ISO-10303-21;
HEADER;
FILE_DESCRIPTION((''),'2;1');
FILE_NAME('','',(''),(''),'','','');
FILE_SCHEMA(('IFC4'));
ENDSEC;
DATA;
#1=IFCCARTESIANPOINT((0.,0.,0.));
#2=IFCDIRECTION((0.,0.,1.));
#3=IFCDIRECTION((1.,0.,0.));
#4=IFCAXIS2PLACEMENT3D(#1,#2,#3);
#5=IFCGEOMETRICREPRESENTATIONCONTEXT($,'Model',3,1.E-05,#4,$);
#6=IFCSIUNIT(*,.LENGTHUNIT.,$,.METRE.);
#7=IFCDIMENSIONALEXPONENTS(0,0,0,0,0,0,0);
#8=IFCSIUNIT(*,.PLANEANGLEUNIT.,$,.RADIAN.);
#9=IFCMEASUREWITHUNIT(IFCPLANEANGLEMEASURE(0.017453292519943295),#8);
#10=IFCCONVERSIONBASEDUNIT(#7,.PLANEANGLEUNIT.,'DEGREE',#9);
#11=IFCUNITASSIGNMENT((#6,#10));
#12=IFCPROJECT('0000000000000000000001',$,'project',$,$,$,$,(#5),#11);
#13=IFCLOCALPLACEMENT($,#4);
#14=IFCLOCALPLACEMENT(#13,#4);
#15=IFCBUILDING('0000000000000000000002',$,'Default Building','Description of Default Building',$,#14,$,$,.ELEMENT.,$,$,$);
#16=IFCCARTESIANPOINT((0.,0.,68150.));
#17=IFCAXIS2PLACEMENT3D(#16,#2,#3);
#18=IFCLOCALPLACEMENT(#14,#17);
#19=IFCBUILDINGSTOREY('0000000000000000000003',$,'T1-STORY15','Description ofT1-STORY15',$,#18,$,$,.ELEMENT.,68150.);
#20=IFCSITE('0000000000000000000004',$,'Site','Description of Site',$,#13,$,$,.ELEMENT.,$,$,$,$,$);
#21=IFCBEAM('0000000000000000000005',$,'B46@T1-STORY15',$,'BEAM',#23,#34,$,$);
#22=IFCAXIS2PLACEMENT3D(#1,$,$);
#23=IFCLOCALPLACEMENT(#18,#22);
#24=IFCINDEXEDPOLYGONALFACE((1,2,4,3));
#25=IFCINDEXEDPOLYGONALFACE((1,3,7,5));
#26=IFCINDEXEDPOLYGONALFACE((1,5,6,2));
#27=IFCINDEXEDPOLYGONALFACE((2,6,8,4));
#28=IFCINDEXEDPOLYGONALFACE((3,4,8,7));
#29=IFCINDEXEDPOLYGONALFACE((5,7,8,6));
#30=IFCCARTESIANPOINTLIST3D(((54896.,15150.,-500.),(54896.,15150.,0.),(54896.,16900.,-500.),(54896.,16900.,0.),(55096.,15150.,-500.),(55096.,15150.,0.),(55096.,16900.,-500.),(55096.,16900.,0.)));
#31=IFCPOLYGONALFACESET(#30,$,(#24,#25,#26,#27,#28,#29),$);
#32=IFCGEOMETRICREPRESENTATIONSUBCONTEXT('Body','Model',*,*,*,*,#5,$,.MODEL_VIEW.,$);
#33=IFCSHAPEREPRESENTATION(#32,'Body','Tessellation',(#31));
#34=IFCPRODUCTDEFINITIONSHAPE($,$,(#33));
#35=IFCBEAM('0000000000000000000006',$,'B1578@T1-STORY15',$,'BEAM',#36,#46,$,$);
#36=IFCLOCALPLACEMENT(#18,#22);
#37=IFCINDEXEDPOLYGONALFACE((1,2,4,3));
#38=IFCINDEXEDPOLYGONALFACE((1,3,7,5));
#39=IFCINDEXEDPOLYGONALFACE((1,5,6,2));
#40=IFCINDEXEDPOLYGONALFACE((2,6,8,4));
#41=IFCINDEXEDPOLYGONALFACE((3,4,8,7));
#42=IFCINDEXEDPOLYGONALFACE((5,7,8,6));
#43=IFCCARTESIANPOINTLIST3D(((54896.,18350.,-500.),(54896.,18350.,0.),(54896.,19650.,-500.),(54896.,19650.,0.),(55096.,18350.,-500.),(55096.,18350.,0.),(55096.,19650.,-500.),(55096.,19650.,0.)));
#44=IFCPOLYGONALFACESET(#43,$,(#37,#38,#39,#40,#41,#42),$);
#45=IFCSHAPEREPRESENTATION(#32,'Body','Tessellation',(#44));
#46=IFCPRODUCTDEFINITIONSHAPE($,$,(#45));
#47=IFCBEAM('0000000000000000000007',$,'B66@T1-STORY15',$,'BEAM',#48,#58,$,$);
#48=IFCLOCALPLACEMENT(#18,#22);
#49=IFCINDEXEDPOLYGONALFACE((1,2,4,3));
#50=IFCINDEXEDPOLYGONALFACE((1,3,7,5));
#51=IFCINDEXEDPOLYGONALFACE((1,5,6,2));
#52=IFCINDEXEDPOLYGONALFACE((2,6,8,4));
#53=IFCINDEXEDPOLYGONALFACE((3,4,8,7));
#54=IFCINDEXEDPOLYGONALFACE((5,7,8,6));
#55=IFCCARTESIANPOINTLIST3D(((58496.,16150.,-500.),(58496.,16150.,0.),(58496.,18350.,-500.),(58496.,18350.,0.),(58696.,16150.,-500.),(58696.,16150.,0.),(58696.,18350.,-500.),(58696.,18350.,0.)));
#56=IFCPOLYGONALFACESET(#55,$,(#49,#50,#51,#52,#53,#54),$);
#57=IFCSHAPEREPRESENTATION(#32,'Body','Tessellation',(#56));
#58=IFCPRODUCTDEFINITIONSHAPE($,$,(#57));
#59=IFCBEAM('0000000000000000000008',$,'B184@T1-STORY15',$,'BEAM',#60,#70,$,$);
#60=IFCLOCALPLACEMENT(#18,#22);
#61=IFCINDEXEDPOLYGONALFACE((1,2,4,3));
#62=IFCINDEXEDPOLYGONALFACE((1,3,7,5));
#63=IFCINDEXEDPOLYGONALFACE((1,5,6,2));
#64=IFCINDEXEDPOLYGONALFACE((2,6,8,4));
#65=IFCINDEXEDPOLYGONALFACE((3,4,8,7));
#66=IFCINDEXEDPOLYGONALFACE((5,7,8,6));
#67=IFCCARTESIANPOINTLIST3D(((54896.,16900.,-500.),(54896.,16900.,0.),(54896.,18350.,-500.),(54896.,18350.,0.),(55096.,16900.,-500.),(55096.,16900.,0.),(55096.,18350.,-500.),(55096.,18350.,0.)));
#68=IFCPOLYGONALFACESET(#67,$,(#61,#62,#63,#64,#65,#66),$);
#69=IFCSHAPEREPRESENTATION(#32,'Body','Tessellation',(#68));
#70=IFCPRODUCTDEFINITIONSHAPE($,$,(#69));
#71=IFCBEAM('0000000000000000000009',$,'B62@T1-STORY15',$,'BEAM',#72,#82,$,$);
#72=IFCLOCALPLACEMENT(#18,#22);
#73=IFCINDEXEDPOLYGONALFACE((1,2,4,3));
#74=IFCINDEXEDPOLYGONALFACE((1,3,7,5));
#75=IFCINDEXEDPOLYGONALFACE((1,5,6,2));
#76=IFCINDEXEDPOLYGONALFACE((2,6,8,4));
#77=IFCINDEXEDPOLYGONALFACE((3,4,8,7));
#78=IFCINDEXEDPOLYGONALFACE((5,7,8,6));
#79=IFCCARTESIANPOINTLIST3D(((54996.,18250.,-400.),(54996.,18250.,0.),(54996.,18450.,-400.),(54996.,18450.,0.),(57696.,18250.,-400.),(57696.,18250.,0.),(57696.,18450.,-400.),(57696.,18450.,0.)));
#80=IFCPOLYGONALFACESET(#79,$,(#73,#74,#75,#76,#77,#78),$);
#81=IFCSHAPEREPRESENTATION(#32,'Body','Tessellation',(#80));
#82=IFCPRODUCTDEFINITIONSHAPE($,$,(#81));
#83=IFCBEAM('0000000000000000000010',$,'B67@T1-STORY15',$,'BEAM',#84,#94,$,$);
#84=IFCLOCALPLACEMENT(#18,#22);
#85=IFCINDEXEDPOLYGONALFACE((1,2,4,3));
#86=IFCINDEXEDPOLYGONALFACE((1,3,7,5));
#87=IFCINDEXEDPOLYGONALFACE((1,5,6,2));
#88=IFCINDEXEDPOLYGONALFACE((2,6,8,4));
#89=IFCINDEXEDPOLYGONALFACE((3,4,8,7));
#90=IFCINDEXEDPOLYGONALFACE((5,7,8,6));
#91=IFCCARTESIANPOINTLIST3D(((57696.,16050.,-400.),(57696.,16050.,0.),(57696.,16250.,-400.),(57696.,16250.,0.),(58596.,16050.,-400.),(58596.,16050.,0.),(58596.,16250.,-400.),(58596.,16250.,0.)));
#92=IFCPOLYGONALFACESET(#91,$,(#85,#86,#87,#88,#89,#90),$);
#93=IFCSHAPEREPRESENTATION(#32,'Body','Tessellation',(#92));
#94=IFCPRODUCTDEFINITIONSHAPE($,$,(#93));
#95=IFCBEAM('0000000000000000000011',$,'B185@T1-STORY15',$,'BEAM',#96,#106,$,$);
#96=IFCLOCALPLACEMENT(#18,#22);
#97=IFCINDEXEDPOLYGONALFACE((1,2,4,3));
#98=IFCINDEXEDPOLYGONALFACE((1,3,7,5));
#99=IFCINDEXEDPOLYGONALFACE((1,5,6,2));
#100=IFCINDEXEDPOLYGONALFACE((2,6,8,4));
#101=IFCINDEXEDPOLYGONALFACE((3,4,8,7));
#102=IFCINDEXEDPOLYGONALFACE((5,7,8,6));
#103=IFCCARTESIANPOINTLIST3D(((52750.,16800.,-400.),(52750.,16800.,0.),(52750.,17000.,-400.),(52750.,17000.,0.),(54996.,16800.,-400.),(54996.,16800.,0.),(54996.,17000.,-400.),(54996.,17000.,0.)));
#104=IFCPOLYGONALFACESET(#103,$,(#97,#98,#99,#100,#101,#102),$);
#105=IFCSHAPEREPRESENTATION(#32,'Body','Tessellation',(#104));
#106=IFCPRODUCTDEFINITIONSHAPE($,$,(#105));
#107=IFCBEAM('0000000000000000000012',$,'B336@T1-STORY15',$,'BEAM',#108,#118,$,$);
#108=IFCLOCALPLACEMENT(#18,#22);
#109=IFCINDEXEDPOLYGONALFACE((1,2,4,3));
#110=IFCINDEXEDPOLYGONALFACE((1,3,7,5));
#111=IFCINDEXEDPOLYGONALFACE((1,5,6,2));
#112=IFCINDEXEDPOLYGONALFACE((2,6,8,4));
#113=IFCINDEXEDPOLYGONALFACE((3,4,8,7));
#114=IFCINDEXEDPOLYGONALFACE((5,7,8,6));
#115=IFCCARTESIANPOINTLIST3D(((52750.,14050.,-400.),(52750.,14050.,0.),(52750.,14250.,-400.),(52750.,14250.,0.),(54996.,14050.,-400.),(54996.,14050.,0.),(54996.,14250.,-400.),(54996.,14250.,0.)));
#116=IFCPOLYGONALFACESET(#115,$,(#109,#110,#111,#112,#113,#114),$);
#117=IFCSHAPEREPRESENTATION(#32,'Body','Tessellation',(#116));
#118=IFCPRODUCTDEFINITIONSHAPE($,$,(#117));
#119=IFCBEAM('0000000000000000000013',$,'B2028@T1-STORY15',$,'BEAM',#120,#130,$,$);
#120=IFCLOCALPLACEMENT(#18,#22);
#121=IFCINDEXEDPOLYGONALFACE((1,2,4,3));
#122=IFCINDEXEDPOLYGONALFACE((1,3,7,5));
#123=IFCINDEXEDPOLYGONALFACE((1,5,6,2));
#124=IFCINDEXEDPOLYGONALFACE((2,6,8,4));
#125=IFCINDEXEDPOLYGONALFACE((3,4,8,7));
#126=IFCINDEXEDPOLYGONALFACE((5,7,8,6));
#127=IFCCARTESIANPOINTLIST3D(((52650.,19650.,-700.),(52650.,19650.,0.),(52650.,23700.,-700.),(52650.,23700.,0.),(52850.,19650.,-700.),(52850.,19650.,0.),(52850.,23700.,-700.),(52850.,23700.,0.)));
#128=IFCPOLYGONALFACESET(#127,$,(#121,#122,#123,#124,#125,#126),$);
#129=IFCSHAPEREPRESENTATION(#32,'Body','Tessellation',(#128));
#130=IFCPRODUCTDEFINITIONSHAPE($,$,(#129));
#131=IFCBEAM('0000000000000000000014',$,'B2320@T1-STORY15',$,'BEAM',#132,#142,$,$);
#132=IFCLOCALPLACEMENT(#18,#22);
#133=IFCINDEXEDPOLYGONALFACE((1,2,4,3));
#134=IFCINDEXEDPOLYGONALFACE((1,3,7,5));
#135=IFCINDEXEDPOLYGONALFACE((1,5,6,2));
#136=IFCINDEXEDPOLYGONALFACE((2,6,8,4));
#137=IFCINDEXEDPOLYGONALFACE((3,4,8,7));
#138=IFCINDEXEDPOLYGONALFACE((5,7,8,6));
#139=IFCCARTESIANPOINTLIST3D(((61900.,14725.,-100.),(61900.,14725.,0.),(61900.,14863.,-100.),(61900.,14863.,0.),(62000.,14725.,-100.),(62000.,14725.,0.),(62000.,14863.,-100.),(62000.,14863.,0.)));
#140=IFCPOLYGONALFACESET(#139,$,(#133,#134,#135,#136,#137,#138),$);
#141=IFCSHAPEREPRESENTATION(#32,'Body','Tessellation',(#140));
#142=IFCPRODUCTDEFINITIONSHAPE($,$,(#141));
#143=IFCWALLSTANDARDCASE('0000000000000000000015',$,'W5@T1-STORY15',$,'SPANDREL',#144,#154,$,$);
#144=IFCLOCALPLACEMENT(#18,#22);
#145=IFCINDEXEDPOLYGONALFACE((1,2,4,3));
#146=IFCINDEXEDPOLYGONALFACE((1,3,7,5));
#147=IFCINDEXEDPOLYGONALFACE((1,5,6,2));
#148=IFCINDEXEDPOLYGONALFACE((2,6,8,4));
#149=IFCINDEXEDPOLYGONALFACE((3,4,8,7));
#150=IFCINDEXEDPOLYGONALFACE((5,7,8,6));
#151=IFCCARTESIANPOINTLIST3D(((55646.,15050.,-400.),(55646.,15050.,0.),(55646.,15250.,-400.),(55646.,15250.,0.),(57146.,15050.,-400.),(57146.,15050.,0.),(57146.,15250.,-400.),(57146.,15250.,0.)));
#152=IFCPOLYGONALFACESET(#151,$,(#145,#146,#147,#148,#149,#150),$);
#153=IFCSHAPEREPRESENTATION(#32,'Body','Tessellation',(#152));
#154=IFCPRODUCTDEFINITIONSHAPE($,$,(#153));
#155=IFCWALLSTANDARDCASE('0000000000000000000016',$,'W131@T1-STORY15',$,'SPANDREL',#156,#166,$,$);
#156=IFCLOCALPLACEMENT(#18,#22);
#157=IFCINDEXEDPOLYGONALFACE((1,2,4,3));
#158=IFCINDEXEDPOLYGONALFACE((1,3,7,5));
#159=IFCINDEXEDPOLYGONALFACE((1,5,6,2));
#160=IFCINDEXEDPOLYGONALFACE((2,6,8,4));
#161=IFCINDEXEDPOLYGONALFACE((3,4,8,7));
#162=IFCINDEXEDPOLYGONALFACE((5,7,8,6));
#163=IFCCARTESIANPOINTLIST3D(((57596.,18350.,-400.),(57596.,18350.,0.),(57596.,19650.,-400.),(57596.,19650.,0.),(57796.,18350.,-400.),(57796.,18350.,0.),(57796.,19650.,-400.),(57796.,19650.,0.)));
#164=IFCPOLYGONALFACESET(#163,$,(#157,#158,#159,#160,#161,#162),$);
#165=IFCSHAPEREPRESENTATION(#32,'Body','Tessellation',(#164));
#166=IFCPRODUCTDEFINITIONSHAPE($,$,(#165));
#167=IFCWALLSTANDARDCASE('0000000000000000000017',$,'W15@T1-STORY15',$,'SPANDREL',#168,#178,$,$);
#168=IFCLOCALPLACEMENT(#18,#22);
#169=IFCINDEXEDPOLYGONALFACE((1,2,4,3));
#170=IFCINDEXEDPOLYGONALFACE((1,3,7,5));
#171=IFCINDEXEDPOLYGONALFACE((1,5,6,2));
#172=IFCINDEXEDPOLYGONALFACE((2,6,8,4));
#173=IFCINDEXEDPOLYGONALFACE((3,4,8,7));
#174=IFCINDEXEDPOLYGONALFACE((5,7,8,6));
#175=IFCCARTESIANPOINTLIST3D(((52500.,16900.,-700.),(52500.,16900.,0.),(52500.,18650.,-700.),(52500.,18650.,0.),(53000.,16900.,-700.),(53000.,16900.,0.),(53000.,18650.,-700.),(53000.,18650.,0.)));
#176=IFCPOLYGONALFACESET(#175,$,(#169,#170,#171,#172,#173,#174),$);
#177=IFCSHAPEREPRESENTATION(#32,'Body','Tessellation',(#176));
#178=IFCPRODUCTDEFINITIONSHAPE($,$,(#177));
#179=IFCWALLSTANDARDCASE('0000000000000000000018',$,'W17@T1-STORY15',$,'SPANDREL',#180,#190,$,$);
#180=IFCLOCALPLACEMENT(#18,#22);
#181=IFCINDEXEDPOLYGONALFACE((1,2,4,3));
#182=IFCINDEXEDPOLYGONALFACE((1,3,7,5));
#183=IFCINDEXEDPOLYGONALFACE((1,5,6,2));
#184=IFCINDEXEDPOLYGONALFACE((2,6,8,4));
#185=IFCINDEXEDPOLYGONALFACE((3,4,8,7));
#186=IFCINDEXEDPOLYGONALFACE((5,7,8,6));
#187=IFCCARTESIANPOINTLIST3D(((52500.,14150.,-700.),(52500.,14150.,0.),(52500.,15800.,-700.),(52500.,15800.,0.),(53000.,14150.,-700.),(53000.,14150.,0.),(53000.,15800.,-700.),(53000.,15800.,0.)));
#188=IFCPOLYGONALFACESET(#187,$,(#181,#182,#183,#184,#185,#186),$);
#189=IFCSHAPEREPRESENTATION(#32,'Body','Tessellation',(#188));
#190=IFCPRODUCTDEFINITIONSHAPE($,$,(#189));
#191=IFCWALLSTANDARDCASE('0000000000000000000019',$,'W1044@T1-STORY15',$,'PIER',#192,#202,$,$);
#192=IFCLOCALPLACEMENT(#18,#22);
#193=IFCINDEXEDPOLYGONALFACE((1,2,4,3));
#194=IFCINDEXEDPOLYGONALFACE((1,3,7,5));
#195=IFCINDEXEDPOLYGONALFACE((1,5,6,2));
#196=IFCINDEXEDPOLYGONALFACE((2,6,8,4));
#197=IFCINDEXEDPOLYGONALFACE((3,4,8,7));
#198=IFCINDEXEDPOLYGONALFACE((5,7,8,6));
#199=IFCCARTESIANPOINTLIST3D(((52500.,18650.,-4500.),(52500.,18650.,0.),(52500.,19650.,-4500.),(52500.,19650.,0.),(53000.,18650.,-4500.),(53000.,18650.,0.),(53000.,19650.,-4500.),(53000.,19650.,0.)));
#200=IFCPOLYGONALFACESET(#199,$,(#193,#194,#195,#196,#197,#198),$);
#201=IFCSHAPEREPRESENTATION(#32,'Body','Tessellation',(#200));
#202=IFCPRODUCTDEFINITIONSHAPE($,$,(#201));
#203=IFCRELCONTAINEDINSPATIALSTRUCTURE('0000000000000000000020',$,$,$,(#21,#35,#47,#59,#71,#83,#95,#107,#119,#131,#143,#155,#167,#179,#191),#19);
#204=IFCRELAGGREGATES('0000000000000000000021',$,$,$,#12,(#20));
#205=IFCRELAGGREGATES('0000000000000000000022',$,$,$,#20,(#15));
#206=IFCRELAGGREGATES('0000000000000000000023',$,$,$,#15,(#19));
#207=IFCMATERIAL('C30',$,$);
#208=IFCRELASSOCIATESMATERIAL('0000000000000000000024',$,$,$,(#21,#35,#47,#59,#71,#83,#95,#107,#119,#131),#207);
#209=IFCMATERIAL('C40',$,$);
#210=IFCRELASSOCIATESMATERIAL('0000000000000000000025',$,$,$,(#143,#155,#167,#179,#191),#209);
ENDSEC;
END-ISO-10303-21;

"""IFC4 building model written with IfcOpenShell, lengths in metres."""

from ifc_helpers import new_model, entity, si_unit, converted_unit, frame, origin_with_axes, place, context, subcontext, project, spatial, indexed_curve, rectangle, outline, extrude, material, element, save


model = new_model("IFC4")

# Units and contexts
model_context = context("Model", 3, precision=1e-05, world=origin_with_axes())
body_context = subcontext(model_context, "Body", "Model", "MODEL_VIEW")
ifc_project = project(units=[si_unit("LENGTHUNIT", "METRE"), converted_unit("PLANEANGLEUNIT", "DEGREE", entity("IfcPlaneAngleMeasure", 0.017453292519943295), si_unit("PLANEANGLEUNIT", "RADIAN"), dimensions=[0, 0, 0, 0, 0, 0, 0])], contexts=[model_context])

# Site, building, storey
site_placement = place(None, origin_with_axes())
site = spatial("IfcSite", under=ifc_project, at=site_placement, Name="Site", Description="Description of Site", CompositionType="ELEMENT")
building_placement = place(site_placement, origin_with_axes())
building = spatial("IfcBuilding", under=site, at=building_placement, Name="Default Building", Description="Description of Default Building", CompositionType="ELEMENT")
storey_placement = place(building_placement, frame((0.0, 0.0, 68150.0), z_axis=(0.0, 0.0, 1.0), x_axis=(1.0, 0.0, 0.0)))
storey = spatial("IfcBuildingStorey", under=building, at=storey_placement, Name="T1-STORY15", Description="Description ofT1-STORY15", CompositionType="ELEMENT", Elevation=68150.0)

# Beams
ifc_material_1 = material(Name="C30")
beam_1_placement = place(storey_placement, frame((54996.0, 15150.0, -250.0), z_axis=(0.0, 1.0, 0.0), x_axis=(-1.0, 0.0, 0.0)))
element("IfcBeam", 1, at=beam_1_placement, inside=storey, material=ifc_material_1, Name="B46@T1-STORY15", ObjectType="BEAM", context=body_context, shape_type="SweptSolid", body=[
    extrude(rectangle(XDim=200.0, YDim=500.0), origin_with_axes(), (0.0, 0.0, 1.0), 1750.0),
])
beam_2_placement = place(storey_placement, frame((54996.0, 18350.0, -250.0), z_axis=(0.0, 1.0, 0.0), x_axis=(-1.0, 0.0, 0.0)))
element("IfcBeam", 2, at=beam_2_placement, inside=storey, material=ifc_material_1, Name="B1578@T1-STORY15", ObjectType="BEAM", context=body_context, shape_type="SweptSolid", body=[
    extrude(rectangle(XDim=200.0, YDim=500.0), origin_with_axes(), (0.0, 0.0, 1.0), 1300.0),
])
beam_3_placement = place(storey_placement, frame((58596.0, 16150.0, -250.0), z_axis=(0.0, 1.0, 0.0), x_axis=(-1.0, 0.0, 0.0)))
element("IfcBeam", 3, at=beam_3_placement, inside=storey, material=ifc_material_1, Name="B66@T1-STORY15", ObjectType="BEAM", context=body_context, shape_type="SweptSolid", body=[
    extrude(rectangle(XDim=200.0, YDim=500.0), origin_with_axes(), (0.0, 0.0, 1.0), 2200.0),
])
beam_4_placement = place(storey_placement, frame((54996.0, 16900.0, -250.0), z_axis=(0.0, 1.0, 0.0), x_axis=(-1.0, 0.0, 0.0)))
element("IfcBeam", 4, at=beam_4_placement, inside=storey, material=ifc_material_1, Name="B184@T1-STORY15", ObjectType="BEAM", context=body_context, shape_type="SweptSolid", body=[
    extrude(rectangle(XDim=200.0, YDim=500.0), origin_with_axes(), (0.0, 0.0, 1.0), 1450.0),
])
beam_5_placement = place(storey_placement, frame((54996.0, 18350.0, -200.0), z_axis=(1.0, 0.0, 0.0), x_axis=(0.0, 1.0, 0.0)))
element("IfcBeam", 5, at=beam_5_placement, inside=storey, material=ifc_material_1, Name="B62@T1-STORY15", ObjectType="BEAM", context=body_context, shape_type="SweptSolid", body=[
    extrude(rectangle(XDim=200.0, YDim=400.0), origin_with_axes(), (0.0, 0.0, 1.0), 2700.0),
])
beam_6_placement = place(storey_placement, frame((57696.0, 16150.0, -200.0), z_axis=(1.0, 0.0, 0.0), x_axis=(0.0, 1.0, 0.0)))
element("IfcBeam", 6, at=beam_6_placement, inside=storey, material=ifc_material_1, Name="B67@T1-STORY15", ObjectType="BEAM", context=body_context, shape_type="SweptSolid", body=[
    extrude(rectangle(XDim=200.0, YDim=400.0), origin_with_axes(), (0.0, 0.0, 1.0), 900.0),
])
for number, where, z_axis, x_axis, name in (
    (7, (52750.0, 16900.0, -200.0), (1.0, 0.0, 0.0), (0.0, 1.0, 0.0), "B185@T1-STORY15"),
    (8, (52750.0, 14150.0, -200.0), (1.0, 0.0, 0.0), (0.0, 1.0, 0.0), "B336@T1-STORY15"),
):
    element("IfcBeam", number, at=place(storey_placement, frame(where, z_axis=z_axis, x_axis=x_axis)), inside=storey, material=ifc_material_1, Name=name, ObjectType="BEAM", context=body_context, shape_type="SweptSolid", body=[
        extrude(rectangle(XDim=200.0, YDim=400.0), origin_with_axes(), (0.0, 0.0, 1.0), 2246.0),
    ])
beam_7_placement = place(storey_placement, frame((52750.0, 19650.0, -350.0), z_axis=(0.0, 1.0, 0.0), x_axis=(-1.0, 0.0, 0.0)))
element("IfcBeam", 9, at=beam_7_placement, inside=storey, material=ifc_material_1, Name="B2028@T1-STORY15", ObjectType="BEAM", context=body_context, shape_type="SweptSolid", body=[
    extrude(rectangle(XDim=200.0, YDim=700.0), origin_with_axes(), (0.0, 0.0, 1.0), 4050.0),
])
beam_8_placement = place(storey_placement, frame((61950.0, 14725.0, -50.0), z_axis=(0.0, 1.0, 0.0), x_axis=(-1.0, 0.0, 0.0)))
element("IfcBeam", 10, at=beam_8_placement, inside=storey, material=ifc_material_1, Name="B2320@T1-STORY15", ObjectType="BEAM", context=body_context, shape_type="SweptSolid", body=[
    extrude(rectangle(XDim=100.0, YDim=100.0), origin_with_axes(), (0.0, 0.0, 1.0), 138.0),
])

# Walls
ifc_material_2 = material(Name="C40")
wall_1_placement = place(storey_placement, frame((55646.0, 15150.0, -400.0), z_axis=(0.0, 0.0, 1.0), x_axis=(1.0, 0.0, 0.0)))
element("IfcWallStandardCase", 11, at=wall_1_placement, inside=storey, material=ifc_material_2, Name="W5@T1-STORY15", ObjectType="SPANDREL", context=body_context, shape_type="SweptSolid", body=[
    extrude(outline(indexed_curve([(0.0, -100.0), (0.0, 100.0), (1500.0, 100.0), (1500.0, -100.0), (0.0, -100.0)], self_intersect=False)), origin_with_axes(), (0.0, 0.0, 1.0), 400.0),
])
wall_2_placement = place(storey_placement, frame((57696.0, 18350.0, -400.0), z_axis=(0.0, 0.0, 1.0), x_axis=(0.0, 1.0, 0.0)))
element("IfcWallStandardCase", 12, at=wall_2_placement, inside=storey, material=ifc_material_2, Name="W131@T1-STORY15", ObjectType="SPANDREL", context=body_context, shape_type="SweptSolid", body=[
    extrude(outline(indexed_curve([(0.0, -100.0), (0.0, 100.0), (1300.0, 100.0), (1300.0, -100.0), (0.0, -100.0)], self_intersect=False)), origin_with_axes(), (0.0, 0.0, 1.0), 400.0),
])
wall_3_placement = place(storey_placement, frame((52750.0, 16900.0, -700.0), z_axis=(0.0, 0.0, 1.0), x_axis=(0.0, 1.0, 0.0)))
element("IfcWallStandardCase", 13, at=wall_3_placement, inside=storey, material=ifc_material_2, Name="W15@T1-STORY15", ObjectType="SPANDREL", context=body_context, shape_type="SweptSolid", body=[
    extrude(outline(indexed_curve([(0.0, -250.0), (0.0, 250.0), (1750.0, 250.0), (1750.0, -250.0), (0.0, -250.0)], self_intersect=False)), origin_with_axes(), (0.0, 0.0, 1.0), 700.0),
])
wall_4_placement = place(storey_placement, frame((52750.0, 14150.0, -700.0), z_axis=(0.0, 0.0, 1.0), x_axis=(0.0, 1.0, 0.0)))
element("IfcWallStandardCase", 14, at=wall_4_placement, inside=storey, material=ifc_material_2, Name="W17@T1-STORY15", ObjectType="SPANDREL", context=body_context, shape_type="SweptSolid", body=[
    extrude(outline(indexed_curve([(0.0, -250.0), (0.0, 250.0), (1650.0, 250.0), (1650.0, -250.0), (0.0, -250.0)], self_intersect=False)), origin_with_axes(), (0.0, 0.0, 1.0), 700.0),
])
wall_5_placement = place(storey_placement, frame((52750.0, 18650.0, -4500.0), z_axis=(0.0, 0.0, 1.0), x_axis=(0.0, 1.0, 0.0)))
element("IfcWallStandardCase", 15, at=wall_5_placement, inside=storey, material=ifc_material_2, Name="W1044@T1-STORY15", ObjectType="PIER", context=body_context, shape_type="SweptSolid", body=[
    extrude(outline(indexed_curve([(0.0, -250.0), (0.0, 250.0), (1000.0, 250.0), (1000.0, -250.0), (0.0, -250.0)], self_intersect=False)), origin_with_axes(), (0.0, 0.0, 1.0), 4500.0),
])

save(model, "model.ifc")
